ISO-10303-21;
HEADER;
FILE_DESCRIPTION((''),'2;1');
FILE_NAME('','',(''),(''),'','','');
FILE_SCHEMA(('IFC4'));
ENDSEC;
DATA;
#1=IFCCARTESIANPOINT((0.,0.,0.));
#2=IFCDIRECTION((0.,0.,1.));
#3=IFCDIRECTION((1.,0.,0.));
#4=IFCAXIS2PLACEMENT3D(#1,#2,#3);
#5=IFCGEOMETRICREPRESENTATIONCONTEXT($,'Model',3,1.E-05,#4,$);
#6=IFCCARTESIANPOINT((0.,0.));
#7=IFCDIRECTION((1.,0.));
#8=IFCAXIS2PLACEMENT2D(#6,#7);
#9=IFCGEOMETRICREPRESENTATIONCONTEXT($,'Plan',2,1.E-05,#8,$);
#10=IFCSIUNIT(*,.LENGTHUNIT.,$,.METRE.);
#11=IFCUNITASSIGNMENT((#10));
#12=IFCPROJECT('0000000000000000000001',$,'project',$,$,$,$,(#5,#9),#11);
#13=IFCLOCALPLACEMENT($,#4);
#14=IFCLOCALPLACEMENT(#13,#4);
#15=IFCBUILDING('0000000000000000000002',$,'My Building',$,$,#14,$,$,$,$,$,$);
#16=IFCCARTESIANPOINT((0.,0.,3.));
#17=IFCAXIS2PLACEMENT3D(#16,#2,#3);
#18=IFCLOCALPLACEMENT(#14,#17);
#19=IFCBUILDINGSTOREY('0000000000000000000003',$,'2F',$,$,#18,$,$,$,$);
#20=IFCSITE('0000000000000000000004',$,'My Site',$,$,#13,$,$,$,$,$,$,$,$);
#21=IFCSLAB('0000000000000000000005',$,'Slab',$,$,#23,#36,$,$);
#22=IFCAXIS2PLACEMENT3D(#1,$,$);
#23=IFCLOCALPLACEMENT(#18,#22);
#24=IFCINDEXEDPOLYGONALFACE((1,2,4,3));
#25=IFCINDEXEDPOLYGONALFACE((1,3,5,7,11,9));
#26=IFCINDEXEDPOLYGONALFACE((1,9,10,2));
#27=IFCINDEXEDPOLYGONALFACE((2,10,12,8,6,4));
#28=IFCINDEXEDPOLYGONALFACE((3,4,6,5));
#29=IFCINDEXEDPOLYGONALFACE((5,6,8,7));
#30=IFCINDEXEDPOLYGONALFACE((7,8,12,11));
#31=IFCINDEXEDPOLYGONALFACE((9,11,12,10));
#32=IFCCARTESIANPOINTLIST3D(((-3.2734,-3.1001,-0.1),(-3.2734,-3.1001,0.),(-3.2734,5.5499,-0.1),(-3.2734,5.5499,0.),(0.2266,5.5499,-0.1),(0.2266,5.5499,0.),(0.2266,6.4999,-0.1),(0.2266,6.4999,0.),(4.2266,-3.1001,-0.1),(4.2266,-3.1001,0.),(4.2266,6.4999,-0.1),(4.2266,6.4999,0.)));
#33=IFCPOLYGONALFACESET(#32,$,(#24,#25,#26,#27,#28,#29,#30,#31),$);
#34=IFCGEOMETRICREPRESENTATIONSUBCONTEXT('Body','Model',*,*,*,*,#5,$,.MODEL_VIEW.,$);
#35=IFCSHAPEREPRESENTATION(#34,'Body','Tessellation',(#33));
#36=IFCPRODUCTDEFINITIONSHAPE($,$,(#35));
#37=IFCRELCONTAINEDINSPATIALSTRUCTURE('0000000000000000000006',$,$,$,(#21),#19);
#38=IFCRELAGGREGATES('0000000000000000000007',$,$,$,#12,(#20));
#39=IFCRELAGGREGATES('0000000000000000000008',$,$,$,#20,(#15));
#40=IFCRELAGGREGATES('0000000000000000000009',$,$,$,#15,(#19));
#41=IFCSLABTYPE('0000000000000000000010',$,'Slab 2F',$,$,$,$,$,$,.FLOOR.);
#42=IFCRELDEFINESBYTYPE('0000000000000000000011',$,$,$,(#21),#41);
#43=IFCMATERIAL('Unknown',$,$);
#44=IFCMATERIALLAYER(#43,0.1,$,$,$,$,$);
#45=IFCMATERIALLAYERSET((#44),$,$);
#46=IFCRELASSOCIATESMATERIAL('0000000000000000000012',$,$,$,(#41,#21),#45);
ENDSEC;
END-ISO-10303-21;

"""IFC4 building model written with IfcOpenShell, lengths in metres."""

from ifc_helpers import new_model, si_unit, frame, origin_with_axes, origin_2d_with_axis, place, context, subcontext, project, spatial, indexed_curve, outline, extrude, material, layer, layer_set, layer_usage, type_object, element, save


model = new_model("IFC4")

# Units and contexts
model_context = context("Model", 3, precision=1e-05, world=origin_with_axes())
plan_context = context("Plan", 2, precision=1e-05, world=origin_2d_with_axis())
body_context = subcontext(model_context, "Body", "Model", "MODEL_VIEW")
ifc_project = project(units=[si_unit("LENGTHUNIT", "METRE")], contexts=[model_context, plan_context])

# Site, building, storey
site_placement = place(None, origin_with_axes())
site = spatial("IfcSite", under=ifc_project, at=site_placement, Name="My Site")
building_placement = place(site_placement, origin_with_axes())
building = spatial("IfcBuilding", under=site, at=building_placement, Name="My Building")
storey_placement = place(building_placement, frame((0.0, 0.0, 3.0), z_axis=(0.0, 0.0, 1.0), x_axis=(1.0, 0.0, 0.0)))
storey = spatial("IfcBuildingStorey", under=building, at=storey_placement, Name="2F")

# Slab
ifc_material = material(Name="Unknown")
ifc_layer = layer(ifc_material, 0.1)
ifc_layer_set = layer_set([ifc_layer])
ifc_layer_usage = layer_usage(ifc_layer_set, "AXIS3", "POSITIVE", -0.1)
slab_type = type_object("IfcSlabType", Name="Slab 2F", PredefinedType="FLOOR", material=ifc_layer_set)
slab_placement = place(storey_placement, frame((4.2266, -3.1001, 0.0), z_axis=(0.0, 0.0, 1.0), x_axis=(1.0, 0.0, 0.0)))
element("IfcSlab", 1, at=slab_placement, inside=storey, type_object=slab_type, material=ifc_layer_usage, Name="Slab", context=body_context, shape_type="SweptSolid", body=[
    extrude(outline(indexed_curve([(0.0, 0.0), (-7.5, 0.0), (-7.5, 8.65), (-4.0, 8.65), (-4.0, 9.6), (0.0, 9.6), (0.0, 0.0)])), frame((0.0, 0.0, -0.1), z_axis=(0.0, 0.0, 1.0), x_axis=(1.0, 0.0, 0.0)), (0.0, 0.0, 1.0), 0.1),
])

save(model, "model.ifc")
